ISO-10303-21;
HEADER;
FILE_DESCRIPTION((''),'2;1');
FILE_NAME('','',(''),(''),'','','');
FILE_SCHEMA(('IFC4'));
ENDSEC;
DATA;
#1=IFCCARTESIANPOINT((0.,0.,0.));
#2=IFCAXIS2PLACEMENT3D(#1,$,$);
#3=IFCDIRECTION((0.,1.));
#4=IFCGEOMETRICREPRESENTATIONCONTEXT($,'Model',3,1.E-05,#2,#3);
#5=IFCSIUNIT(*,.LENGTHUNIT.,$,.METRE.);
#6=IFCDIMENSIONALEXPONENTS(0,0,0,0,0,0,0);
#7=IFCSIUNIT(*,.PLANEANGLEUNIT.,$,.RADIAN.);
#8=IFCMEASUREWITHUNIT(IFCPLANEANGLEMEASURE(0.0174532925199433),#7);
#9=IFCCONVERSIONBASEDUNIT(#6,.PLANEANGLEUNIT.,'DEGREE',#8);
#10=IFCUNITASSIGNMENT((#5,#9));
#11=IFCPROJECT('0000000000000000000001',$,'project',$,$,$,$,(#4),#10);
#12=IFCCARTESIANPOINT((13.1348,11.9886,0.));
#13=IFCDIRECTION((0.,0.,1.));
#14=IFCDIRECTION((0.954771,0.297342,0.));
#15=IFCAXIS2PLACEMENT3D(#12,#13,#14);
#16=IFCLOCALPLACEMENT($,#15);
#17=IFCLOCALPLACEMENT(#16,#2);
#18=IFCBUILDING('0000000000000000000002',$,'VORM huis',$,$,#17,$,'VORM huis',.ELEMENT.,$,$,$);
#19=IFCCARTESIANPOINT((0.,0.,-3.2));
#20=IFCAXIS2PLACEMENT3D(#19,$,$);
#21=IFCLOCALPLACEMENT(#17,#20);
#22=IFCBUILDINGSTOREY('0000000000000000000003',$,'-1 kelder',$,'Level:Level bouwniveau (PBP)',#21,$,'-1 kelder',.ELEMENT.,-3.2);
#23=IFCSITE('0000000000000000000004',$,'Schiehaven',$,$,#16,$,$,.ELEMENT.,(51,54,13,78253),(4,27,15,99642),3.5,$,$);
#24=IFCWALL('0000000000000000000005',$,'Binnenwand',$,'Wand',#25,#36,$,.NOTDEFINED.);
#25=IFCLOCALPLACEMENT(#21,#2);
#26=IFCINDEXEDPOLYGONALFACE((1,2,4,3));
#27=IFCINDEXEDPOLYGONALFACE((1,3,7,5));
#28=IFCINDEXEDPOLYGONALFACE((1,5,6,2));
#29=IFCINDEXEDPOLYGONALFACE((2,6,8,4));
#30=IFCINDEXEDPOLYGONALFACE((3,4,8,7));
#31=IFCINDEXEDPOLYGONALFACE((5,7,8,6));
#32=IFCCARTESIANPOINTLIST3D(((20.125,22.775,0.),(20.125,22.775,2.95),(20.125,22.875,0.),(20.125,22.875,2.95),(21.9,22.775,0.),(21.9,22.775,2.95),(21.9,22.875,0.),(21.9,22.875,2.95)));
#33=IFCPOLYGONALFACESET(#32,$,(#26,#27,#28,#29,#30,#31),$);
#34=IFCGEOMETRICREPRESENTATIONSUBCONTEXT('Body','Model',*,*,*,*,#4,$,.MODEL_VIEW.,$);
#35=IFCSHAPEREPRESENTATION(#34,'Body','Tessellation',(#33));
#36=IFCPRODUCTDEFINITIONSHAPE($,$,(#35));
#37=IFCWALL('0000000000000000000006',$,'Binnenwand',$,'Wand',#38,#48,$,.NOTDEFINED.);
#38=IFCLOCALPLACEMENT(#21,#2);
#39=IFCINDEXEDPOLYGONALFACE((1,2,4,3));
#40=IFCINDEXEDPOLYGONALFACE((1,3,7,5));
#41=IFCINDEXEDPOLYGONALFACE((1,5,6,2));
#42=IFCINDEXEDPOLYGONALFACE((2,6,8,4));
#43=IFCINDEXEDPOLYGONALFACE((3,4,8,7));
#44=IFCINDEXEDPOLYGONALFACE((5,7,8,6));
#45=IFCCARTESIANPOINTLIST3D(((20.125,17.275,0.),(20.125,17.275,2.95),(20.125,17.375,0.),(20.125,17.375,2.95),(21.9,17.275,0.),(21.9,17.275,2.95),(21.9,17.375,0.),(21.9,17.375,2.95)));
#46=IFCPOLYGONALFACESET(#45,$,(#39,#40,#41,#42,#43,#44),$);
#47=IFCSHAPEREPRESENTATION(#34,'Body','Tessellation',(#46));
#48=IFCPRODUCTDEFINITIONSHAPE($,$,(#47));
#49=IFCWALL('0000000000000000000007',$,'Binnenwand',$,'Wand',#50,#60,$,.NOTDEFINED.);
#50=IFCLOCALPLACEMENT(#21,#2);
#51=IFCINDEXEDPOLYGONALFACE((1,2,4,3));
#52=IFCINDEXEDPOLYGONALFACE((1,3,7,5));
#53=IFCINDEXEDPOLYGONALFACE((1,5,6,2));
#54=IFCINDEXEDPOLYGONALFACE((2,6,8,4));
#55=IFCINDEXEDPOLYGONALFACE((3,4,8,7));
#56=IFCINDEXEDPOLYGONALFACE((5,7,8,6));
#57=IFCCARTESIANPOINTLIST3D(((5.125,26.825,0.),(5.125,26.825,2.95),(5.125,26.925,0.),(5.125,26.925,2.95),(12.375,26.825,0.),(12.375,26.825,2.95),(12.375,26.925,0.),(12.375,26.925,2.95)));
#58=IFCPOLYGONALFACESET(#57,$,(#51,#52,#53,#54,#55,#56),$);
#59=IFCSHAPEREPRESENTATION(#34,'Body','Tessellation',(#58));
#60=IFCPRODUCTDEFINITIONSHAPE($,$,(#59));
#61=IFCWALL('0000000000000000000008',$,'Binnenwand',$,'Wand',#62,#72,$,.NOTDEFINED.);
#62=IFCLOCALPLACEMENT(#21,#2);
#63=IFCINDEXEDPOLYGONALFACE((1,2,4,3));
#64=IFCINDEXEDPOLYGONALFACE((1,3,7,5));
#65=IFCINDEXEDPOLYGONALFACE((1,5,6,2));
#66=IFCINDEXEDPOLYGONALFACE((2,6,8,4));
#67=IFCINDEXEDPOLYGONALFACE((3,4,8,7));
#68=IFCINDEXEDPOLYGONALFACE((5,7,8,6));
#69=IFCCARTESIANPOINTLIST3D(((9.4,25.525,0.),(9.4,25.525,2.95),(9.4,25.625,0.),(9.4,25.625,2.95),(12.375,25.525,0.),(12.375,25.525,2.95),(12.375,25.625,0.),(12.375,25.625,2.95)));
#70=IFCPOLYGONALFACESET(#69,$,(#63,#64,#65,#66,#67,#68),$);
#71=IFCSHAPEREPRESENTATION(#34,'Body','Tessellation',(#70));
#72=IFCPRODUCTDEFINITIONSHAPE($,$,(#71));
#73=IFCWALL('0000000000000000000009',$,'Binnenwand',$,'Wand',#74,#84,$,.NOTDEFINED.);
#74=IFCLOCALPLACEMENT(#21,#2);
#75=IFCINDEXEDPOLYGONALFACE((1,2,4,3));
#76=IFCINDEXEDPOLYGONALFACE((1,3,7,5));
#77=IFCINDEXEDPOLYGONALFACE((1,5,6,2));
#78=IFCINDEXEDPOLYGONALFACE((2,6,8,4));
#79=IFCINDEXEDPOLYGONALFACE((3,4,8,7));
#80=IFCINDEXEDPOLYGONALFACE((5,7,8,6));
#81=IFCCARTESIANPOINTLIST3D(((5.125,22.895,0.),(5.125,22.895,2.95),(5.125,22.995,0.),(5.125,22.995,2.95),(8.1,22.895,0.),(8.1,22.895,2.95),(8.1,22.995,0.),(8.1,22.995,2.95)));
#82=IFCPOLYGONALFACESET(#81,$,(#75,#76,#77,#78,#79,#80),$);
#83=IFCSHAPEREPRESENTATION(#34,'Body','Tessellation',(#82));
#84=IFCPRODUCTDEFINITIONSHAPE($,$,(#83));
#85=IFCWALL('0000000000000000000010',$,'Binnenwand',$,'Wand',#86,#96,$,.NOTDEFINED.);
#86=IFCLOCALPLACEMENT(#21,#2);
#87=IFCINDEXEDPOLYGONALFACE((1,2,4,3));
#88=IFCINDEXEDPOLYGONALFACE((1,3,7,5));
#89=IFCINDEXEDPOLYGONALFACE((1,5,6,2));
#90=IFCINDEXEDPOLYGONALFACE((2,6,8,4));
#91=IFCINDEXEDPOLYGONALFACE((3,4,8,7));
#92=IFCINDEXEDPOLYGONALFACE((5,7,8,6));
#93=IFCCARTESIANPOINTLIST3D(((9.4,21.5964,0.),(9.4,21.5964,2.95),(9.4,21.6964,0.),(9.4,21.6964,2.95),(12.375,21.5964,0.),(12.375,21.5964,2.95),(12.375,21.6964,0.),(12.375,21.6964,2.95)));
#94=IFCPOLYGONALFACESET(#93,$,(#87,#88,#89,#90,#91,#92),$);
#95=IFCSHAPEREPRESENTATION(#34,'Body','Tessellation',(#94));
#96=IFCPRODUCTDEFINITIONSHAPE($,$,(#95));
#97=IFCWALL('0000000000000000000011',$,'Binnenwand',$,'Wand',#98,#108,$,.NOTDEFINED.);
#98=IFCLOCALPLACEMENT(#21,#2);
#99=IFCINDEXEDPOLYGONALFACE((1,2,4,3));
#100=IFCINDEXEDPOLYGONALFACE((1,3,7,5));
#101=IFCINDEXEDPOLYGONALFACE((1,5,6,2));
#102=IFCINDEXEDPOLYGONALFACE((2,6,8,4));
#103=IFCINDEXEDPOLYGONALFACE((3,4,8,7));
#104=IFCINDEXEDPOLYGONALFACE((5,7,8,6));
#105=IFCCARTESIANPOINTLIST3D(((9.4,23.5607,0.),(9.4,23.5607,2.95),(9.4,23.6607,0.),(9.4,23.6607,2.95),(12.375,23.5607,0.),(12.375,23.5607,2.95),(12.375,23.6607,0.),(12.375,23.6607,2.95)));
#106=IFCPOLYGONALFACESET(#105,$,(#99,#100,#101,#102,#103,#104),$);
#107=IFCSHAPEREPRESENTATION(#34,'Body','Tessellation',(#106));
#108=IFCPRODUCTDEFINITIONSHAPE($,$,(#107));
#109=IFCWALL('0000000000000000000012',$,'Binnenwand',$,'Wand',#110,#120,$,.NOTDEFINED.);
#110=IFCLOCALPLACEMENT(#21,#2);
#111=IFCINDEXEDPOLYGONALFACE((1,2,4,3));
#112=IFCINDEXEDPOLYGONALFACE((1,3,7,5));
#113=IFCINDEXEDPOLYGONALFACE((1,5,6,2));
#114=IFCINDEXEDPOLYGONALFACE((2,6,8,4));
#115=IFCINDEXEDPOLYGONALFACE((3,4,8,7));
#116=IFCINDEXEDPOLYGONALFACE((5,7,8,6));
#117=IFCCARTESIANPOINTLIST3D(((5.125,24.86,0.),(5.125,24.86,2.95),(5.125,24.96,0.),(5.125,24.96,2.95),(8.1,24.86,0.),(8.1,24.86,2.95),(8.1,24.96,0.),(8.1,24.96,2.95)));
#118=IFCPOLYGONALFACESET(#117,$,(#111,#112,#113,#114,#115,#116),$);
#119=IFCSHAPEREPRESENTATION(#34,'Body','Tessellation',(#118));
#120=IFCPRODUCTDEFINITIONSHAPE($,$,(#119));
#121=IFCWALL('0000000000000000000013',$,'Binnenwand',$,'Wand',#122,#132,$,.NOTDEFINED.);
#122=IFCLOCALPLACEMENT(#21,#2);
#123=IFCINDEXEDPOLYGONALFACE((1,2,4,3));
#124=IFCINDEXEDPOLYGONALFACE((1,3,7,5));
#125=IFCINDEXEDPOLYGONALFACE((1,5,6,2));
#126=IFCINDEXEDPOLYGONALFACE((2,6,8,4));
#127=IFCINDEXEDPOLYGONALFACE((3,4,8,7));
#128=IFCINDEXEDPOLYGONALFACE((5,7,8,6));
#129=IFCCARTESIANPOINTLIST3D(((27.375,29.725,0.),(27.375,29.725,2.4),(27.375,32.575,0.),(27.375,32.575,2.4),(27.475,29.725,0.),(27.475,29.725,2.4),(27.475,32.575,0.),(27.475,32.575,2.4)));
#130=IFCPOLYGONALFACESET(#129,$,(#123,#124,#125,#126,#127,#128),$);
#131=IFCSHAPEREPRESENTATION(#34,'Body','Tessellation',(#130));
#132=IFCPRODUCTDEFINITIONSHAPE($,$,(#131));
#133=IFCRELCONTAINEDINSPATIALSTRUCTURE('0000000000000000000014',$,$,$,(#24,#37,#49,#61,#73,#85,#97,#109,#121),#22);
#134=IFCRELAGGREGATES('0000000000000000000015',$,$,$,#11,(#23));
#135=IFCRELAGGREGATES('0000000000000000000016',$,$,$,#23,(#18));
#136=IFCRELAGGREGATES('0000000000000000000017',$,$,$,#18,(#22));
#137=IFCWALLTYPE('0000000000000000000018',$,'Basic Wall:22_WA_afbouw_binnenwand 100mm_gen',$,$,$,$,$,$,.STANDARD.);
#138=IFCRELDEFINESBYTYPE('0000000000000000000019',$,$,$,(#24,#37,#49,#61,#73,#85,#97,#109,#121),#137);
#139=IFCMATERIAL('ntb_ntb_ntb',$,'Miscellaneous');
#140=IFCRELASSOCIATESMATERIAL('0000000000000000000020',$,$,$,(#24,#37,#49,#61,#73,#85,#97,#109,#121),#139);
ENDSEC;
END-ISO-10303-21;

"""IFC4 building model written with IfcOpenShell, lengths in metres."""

from ifc_helpers import new_model, entity, si_unit, converted_unit, direction, frame, origin, place, context, subcontext, project, spatial, indexed_curve, outline, extrude, material, type_object, element, save


model = new_model("IFC4")

# Units and contexts
model_context = context("Model", 3, precision=1e-05, world=origin(), true_north=direction((0.0, 1.0)))
body_context = subcontext(model_context, "Body", "Model", "MODEL_VIEW")
ifc_project = project(units=[si_unit("LENGTHUNIT", "METRE"), converted_unit("PLANEANGLEUNIT", "DEGREE", entity("IfcPlaneAngleMeasure", 0.0174532925199433), si_unit("PLANEANGLEUNIT", "RADIAN"), dimensions=[0, 0, 0, 0, 0, 0, 0])], contexts=[model_context])

# Site, building, storey
site_placement = place(None, frame((13.1348, 11.9886, 0.0), z_axis=(0.0, 0.0, 1.0), x_axis=(0.954771, 0.297342, 0.0)))
site = spatial("IfcSite", under=ifc_project, at=site_placement, Name="Schiehaven", CompositionType="ELEMENT", RefLatitude=(51, 54, 13, 78253), RefLongitude=(4, 27, 15, 99642), RefElevation=3.5)
building_placement = place(site_placement, origin())
building = spatial("IfcBuilding", under=site, at=building_placement, Name="VORM huis", LongName="VORM huis", CompositionType="ELEMENT")
storey_placement = place(building_placement, frame((0.0, 0.0, -3.2)))
storey = spatial("IfcBuildingStorey", under=building, at=storey_placement, Name="-1 kelder", ObjectType="Level:Level bouwniveau (PBP)", LongName="-1 kelder", CompositionType="ELEMENT", Elevation=-3.2)

# Walls
ifc_material_1 = material(Name="ntb_ntb_ntb", Category="Miscellaneous")
wall_type_1 = type_object("IfcWallType", Name="Basic Wall:22_WA_afbouw_binnenwand 100mm_gen", PredefinedType="STANDARD")
wall_1_placement = place(storey_placement, frame((21.9, 22.825, 0.0), z_axis=(0.0, 0.0, 1.0), x_axis=(-1.0, 0.0, 0.0)))
element("IfcWall", 1, at=wall_1_placement, inside=storey, type_object=wall_type_1, material=ifc_material_1, Name="Binnenwand", ObjectType="Wand", PredefinedType="NOTDEFINED", context=body_context, shape_type="SweptSolid", body=[
    extrude(outline(indexed_curve([(1.775, 0.05), (0.0, 0.05), (0.0, -0.05), (1.775, -0.05), (1.775, 0.05)], self_intersect=False)), origin(), (0.0, 0.0, 1.0), 2.95),
])
wall_2_placement = place(storey_placement, frame((21.9, 17.325, 0.0), z_axis=(0.0, 0.0, 1.0), x_axis=(-1.0, 0.0, 0.0)))
element("IfcWall", 2, at=wall_2_placement, inside=storey, type_object=wall_type_1, material=ifc_material_1, Name="Binnenwand", ObjectType="Wand", PredefinedType="NOTDEFINED", context=body_context, shape_type="SweptSolid", body=[
    extrude(outline(indexed_curve([(1.775, 0.05), (0.0, 0.05), (0.0, -0.05), (1.775, -0.05), (1.775, 0.05)], self_intersect=False)), origin(), (0.0, 0.0, 1.0), 2.95),
])
wall_3_placement = place(storey_placement, frame((5.125, 26.875, 0.0)))
element("IfcWall", 3, at=wall_3_placement, inside=storey, type_object=wall_type_1, material=ifc_material_1, Name="Binnenwand", ObjectType="Wand", PredefinedType="NOTDEFINED", context=body_context, shape_type="SweptSolid", body=[
    extrude(outline(indexed_curve([(7.25, 0.05), (0.0, 0.05), (0.0, -0.05), (7.25, -0.05), (7.25, 0.05)], self_intersect=False)), origin(), (0.0, 0.0, 1.0), 2.95),
])
wall_4_placement = place(storey_placement, frame((9.4, 25.575, 0.0)))
element("IfcWall", 4, at=wall_4_placement, inside=storey, type_object=wall_type_1, material=ifc_material_1, Name="Binnenwand", ObjectType="Wand", PredefinedType="NOTDEFINED", context=body_context, shape_type="SweptSolid", body=[
    extrude(outline(indexed_curve([(2.975, 0.05), (0.0, 0.05), (0.0, -0.05), (2.975, -0.05), (2.975, 0.05)], self_intersect=False)), origin(), (0.0, 0.0, 1.0), 2.95),
])
wall_5_placement = place(storey_placement, frame((8.1, 22.945, 0.0), z_axis=(0.0, 0.0, 1.0), x_axis=(-1.0, 0.0, 0.0)))
element("IfcWall", 5, at=wall_5_placement, inside=storey, type_object=wall_type_1, material=ifc_material_1, Name="Binnenwand", ObjectType="Wand", PredefinedType="NOTDEFINED", context=body_context, shape_type="SweptSolid", body=[
    extrude(outline(indexed_curve([(2.975, 0.05), (0.0, 0.05), (0.0, -0.05), (2.975, -0.05), (2.975, 0.05)], self_intersect=False)), origin(), (0.0, 0.0, 1.0), 2.95),
])
wall_6_placement = place(storey_placement, frame((9.4, 21.6464, 0.0)))
element("IfcWall", 6, at=wall_6_placement, inside=storey, type_object=wall_type_1, material=ifc_material_1, Name="Binnenwand", ObjectType="Wand", PredefinedType="NOTDEFINED", context=body_context, shape_type="SweptSolid", body=[
    extrude(outline(indexed_curve([(2.975, 0.05), (0.0, 0.05), (0.0, -0.05), (2.975, -0.05), (2.975, 0.05)], self_intersect=False)), origin(), (0.0, 0.0, 1.0), 2.95),
])
wall_7_placement = place(storey_placement, frame((9.4, 23.6107, 0.0)))
element("IfcWall", 7, at=wall_7_placement, inside=storey, type_object=wall_type_1, material=ifc_material_1, Name="Binnenwand", ObjectType="Wand", PredefinedType="NOTDEFINED", context=body_context, shape_type="SweptSolid", body=[
    extrude(outline(indexed_curve([(2.975, 0.05), (0.0, 0.05), (0.0, -0.05), (2.975, -0.05), (2.975, 0.05)], self_intersect=False)), origin(), (0.0, 0.0, 1.0), 2.95),
])
wall_8_placement = place(storey_placement, frame((8.1, 24.91, 0.0), z_axis=(0.0, 0.0, 1.0), x_axis=(-1.0, 0.0, 0.0)))
element("IfcWall", 8, at=wall_8_placement, inside=storey, type_object=wall_type_1, material=ifc_material_1, Name="Binnenwand", ObjectType="Wand", PredefinedType="NOTDEFINED", context=body_context, shape_type="SweptSolid", body=[
    extrude(outline(indexed_curve([(2.975, 0.05), (0.0, 0.05), (0.0, -0.05), (2.975, -0.05), (2.975, 0.05)], self_intersect=False)), origin(), (0.0, 0.0, 1.0), 2.95),
])
wall_9_placement = place(storey_placement, frame((27.425, 29.725, 0.0), z_axis=(0.0, 0.0, 1.0), x_axis=(0.0, 1.0, 0.0)))
element("IfcWall", 9, at=wall_9_placement, inside=storey, type_object=wall_type_1, material=ifc_material_1, Name="Binnenwand", ObjectType="Wand", PredefinedType="NOTDEFINED", context=body_context, shape_type="SweptSolid", body=[
    extrude(outline(indexed_curve([(2.85, 0.05), (0.0, 0.05), (0.0, -0.05), (2.85, -0.05), (2.85, 0.05)], self_intersect=False)), origin(), (0.0, 0.0, 1.0), 2.4),
])

save(model, "model.ifc")
